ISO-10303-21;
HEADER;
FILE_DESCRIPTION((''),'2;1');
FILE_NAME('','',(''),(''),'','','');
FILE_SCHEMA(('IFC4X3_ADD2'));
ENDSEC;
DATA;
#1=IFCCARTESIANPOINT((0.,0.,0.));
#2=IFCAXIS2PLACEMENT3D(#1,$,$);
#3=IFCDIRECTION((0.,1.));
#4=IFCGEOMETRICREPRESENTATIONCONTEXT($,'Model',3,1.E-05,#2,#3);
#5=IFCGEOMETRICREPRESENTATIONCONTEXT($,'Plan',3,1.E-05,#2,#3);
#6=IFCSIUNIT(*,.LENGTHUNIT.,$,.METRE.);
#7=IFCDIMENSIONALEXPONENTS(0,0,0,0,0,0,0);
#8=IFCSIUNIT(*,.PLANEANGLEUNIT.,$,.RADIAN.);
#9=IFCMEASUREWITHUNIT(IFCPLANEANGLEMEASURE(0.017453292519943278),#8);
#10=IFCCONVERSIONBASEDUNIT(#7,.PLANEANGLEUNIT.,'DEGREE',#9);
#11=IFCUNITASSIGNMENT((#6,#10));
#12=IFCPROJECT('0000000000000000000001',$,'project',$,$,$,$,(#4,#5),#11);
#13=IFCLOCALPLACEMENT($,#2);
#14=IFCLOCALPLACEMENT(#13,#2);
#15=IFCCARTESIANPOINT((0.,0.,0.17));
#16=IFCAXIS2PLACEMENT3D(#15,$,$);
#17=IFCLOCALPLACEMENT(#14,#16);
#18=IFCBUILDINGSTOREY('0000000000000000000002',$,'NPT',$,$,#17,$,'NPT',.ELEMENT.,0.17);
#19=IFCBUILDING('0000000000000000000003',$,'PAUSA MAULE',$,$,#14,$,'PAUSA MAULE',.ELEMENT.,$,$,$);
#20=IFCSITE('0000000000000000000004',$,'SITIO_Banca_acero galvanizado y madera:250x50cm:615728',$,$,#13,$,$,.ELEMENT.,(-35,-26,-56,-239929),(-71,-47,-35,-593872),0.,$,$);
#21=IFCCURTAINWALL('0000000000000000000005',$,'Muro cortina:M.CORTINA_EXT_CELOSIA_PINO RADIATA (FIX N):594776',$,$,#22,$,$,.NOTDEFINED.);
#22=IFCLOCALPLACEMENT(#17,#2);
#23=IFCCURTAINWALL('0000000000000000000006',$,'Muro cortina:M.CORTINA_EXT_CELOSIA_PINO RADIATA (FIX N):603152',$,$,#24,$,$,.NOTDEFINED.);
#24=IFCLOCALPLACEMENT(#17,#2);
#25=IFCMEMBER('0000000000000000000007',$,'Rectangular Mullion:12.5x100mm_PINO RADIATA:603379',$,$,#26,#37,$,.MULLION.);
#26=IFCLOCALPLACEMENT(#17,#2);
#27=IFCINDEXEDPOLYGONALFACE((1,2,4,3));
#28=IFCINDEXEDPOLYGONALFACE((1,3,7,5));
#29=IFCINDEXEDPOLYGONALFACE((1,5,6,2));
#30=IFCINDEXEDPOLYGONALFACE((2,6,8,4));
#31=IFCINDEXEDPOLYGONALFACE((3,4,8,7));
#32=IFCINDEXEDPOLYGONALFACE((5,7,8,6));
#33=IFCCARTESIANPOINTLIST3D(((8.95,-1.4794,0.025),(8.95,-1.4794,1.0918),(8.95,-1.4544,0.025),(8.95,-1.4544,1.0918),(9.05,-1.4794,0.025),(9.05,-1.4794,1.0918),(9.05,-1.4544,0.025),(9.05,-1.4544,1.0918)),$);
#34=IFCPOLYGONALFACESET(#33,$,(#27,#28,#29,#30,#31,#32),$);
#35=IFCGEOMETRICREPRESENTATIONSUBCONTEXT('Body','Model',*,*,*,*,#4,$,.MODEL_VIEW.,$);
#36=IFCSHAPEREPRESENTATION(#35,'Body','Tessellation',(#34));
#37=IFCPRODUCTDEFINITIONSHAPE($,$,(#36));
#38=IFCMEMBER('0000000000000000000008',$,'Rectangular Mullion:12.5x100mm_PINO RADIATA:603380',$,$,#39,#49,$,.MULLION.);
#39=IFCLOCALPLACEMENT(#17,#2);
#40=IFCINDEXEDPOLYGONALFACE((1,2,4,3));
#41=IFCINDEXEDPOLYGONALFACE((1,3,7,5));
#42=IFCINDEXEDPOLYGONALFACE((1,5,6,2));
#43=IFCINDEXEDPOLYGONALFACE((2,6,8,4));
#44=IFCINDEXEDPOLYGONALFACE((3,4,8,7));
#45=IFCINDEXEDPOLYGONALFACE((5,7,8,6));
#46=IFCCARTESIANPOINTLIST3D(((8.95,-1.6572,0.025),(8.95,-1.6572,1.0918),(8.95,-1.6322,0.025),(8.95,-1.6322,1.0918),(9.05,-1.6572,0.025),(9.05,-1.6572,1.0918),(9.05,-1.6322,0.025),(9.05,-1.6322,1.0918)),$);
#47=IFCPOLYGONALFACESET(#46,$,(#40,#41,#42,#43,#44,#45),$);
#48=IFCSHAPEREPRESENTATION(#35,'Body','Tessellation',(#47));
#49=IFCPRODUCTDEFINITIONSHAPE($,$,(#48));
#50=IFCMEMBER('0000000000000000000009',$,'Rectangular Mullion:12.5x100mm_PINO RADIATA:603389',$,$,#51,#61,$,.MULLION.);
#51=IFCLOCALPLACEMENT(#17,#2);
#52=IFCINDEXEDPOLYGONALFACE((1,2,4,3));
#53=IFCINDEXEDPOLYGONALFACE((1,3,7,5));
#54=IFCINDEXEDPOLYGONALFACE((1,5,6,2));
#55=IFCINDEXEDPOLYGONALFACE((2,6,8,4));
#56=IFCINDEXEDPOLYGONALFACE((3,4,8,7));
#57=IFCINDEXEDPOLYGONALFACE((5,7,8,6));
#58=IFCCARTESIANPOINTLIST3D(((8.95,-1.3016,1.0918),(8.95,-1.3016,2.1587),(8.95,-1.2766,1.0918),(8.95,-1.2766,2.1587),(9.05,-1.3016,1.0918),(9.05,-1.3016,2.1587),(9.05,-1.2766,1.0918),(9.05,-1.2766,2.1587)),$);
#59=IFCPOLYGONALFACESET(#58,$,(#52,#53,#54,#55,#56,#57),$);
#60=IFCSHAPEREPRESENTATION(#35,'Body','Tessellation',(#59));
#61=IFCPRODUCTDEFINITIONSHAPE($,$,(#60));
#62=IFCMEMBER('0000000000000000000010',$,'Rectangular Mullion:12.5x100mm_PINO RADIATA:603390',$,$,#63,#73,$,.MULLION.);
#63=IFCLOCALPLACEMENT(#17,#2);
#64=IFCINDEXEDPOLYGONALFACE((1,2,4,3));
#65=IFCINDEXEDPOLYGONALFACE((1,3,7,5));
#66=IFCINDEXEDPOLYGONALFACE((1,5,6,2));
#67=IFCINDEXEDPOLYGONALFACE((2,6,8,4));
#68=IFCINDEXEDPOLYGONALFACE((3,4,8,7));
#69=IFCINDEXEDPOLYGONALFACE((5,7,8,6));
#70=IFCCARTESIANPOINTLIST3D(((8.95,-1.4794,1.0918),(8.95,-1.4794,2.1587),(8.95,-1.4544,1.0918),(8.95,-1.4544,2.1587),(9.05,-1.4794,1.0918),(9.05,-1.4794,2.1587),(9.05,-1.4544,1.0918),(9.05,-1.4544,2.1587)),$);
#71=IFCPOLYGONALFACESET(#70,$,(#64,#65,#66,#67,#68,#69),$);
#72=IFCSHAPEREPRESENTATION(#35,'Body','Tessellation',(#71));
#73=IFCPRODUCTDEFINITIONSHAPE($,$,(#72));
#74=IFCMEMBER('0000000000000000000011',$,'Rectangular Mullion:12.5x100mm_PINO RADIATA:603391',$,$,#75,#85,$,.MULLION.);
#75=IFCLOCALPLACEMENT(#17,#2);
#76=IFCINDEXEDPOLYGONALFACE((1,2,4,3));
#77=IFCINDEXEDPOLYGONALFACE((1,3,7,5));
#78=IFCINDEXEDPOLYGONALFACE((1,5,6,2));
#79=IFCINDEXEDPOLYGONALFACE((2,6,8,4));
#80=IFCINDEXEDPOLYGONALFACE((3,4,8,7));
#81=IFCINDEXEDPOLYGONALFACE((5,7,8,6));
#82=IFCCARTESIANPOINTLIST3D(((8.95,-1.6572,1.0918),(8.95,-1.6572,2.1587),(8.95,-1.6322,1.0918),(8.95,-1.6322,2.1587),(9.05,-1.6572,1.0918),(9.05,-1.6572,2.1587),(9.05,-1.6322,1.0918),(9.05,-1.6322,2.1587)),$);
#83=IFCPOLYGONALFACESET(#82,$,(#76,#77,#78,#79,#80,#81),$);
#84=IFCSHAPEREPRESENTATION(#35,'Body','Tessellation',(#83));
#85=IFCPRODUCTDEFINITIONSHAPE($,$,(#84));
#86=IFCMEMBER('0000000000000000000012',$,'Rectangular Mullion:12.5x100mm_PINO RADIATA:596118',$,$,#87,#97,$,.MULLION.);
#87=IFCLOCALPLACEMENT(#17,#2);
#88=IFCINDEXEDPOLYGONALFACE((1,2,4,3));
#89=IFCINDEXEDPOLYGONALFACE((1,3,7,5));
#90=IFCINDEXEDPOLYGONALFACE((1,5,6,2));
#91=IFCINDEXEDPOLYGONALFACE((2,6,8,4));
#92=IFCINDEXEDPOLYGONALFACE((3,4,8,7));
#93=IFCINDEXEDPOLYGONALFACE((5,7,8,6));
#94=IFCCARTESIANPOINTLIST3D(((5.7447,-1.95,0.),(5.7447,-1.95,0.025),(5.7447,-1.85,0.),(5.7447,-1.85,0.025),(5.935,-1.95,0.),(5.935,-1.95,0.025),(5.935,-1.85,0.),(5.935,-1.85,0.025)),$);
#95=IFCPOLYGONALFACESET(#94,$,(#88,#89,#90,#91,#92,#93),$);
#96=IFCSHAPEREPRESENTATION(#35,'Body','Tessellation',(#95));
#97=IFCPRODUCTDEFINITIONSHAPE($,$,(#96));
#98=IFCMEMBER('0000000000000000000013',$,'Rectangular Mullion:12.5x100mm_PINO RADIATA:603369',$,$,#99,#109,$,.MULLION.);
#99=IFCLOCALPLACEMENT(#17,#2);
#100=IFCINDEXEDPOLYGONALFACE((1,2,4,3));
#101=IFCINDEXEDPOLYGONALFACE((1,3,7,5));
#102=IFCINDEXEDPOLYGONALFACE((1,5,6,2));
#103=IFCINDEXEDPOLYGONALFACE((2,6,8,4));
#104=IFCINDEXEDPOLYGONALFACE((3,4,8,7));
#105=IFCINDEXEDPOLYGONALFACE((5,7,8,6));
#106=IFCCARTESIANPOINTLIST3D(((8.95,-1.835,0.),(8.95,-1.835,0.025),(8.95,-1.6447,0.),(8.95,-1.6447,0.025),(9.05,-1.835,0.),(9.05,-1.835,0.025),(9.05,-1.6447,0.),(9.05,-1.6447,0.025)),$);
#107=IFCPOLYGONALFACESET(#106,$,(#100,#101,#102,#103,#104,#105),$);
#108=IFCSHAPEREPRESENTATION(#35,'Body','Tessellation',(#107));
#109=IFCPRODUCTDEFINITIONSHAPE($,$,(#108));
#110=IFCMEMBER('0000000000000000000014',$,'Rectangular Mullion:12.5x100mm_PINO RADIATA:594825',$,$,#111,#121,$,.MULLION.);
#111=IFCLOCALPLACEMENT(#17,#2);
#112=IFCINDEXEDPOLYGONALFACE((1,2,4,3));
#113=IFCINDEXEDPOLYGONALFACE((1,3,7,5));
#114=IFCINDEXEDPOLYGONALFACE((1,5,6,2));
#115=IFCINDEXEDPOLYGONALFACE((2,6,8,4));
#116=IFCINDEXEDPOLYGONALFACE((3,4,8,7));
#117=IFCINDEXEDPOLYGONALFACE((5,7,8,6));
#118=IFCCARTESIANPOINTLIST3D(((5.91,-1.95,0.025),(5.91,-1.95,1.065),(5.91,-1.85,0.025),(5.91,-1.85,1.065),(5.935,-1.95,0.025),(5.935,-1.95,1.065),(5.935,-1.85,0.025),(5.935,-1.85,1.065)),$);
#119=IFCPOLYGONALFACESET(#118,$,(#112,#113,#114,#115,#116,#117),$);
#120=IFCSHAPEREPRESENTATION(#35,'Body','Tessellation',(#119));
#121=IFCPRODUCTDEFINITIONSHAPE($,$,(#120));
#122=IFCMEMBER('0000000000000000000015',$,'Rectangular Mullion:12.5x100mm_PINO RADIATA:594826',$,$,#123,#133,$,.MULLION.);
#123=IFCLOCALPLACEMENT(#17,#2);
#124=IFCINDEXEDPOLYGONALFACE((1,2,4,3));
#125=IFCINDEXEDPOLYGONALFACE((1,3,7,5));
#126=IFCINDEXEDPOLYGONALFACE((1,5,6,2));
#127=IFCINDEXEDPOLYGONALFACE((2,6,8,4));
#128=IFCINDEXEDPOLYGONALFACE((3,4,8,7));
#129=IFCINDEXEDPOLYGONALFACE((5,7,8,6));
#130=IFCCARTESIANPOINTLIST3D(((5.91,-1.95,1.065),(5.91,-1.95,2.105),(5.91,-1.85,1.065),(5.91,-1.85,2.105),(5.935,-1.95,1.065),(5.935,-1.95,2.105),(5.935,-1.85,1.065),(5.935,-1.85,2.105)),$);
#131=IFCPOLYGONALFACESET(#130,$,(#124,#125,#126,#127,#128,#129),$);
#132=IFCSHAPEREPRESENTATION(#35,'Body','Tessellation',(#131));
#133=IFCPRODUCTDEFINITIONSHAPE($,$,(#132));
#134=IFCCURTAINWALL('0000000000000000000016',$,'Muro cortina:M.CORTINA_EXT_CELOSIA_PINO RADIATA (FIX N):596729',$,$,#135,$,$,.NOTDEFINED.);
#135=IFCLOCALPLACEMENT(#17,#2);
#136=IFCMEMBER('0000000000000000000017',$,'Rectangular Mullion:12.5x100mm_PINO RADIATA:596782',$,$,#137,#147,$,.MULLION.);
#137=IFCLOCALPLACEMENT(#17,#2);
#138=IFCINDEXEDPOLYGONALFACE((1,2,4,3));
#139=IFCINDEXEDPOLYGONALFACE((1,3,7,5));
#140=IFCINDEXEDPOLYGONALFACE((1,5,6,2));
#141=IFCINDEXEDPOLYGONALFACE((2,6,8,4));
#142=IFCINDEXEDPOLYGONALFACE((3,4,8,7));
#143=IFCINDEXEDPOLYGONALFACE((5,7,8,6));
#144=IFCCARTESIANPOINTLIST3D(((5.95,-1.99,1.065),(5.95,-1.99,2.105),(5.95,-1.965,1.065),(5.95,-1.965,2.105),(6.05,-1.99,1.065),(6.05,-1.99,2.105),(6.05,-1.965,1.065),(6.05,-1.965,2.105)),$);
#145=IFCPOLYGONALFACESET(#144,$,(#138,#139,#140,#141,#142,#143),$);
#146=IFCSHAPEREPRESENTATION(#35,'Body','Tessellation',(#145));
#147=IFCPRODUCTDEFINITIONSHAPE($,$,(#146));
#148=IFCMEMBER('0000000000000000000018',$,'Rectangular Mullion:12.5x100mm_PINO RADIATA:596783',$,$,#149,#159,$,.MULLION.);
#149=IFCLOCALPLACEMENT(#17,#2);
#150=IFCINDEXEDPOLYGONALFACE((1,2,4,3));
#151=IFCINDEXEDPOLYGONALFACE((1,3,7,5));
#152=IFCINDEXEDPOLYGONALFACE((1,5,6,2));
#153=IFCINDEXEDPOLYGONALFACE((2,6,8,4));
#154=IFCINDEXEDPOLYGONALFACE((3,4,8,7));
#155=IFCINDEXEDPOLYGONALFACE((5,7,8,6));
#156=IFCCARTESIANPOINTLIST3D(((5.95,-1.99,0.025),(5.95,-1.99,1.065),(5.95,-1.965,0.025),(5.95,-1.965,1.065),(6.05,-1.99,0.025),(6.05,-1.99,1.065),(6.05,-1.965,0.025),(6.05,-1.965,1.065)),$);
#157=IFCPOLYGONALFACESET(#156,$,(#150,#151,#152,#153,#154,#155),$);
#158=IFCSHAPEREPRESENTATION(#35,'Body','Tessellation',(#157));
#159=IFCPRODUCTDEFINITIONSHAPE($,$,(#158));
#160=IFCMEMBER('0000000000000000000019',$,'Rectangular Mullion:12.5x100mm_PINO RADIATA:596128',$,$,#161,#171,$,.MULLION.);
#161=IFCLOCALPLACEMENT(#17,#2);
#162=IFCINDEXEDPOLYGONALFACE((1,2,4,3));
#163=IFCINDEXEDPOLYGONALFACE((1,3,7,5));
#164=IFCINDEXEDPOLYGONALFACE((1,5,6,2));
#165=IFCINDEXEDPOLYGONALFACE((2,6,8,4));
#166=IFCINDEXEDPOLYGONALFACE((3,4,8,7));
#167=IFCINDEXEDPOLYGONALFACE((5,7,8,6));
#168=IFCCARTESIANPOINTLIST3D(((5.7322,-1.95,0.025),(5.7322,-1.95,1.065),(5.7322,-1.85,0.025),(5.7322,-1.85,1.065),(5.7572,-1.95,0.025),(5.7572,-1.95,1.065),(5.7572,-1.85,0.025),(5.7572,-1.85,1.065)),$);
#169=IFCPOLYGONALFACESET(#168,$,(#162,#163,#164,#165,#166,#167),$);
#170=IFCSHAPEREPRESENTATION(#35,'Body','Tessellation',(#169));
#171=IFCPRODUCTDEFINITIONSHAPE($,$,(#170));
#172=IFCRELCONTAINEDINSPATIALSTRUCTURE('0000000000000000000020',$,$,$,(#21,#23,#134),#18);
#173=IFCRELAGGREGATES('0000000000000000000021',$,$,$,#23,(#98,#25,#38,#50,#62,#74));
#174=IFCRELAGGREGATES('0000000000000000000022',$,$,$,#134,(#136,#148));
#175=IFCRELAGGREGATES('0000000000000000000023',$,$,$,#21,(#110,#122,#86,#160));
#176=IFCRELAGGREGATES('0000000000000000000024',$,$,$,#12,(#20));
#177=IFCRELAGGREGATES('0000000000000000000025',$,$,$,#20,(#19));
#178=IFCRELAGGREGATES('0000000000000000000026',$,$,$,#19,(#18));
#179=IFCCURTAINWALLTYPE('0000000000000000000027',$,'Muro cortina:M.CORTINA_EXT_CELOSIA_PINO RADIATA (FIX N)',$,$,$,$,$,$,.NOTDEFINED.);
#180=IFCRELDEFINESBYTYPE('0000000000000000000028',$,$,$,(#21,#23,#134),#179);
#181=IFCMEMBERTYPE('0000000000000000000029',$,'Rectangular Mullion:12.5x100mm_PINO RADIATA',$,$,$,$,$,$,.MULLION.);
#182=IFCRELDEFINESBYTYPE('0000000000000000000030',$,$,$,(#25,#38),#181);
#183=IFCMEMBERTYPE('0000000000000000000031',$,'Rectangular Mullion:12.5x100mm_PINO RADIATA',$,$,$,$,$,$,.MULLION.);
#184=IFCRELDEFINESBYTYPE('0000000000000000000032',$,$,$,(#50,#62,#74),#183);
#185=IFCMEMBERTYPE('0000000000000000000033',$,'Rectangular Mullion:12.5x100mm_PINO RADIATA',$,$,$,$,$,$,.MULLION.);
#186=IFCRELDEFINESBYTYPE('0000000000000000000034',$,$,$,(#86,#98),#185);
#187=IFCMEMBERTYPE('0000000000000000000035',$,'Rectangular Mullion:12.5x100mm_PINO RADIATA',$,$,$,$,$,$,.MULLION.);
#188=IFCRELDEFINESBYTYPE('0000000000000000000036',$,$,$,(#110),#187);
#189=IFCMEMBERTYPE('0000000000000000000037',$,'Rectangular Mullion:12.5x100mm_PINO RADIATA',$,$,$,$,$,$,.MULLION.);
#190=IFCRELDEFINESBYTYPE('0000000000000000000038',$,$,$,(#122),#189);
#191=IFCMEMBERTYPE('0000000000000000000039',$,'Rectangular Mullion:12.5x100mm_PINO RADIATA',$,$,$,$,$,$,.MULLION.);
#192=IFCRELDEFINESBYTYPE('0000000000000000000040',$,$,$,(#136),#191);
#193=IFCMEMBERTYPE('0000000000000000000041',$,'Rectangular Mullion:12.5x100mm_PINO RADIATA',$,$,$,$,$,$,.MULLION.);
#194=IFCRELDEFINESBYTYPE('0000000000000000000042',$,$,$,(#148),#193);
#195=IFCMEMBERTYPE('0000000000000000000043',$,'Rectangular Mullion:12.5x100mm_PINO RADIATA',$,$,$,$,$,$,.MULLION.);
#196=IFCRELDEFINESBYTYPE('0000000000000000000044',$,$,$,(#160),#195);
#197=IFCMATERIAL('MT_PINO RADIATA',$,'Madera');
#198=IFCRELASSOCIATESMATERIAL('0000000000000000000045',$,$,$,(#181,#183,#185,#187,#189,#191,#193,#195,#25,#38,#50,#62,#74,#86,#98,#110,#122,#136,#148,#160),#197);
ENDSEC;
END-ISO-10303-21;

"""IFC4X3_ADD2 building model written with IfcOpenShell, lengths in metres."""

from ifc_helpers import new_model, entity, si_unit, converted_unit, direction, frame, frame_2d, origin, origin_2d_with_axis, place, context, subcontext, project, spatial, rectangle, extrude, source, transform, mapped, material, material_profile, profile_set, profile_usage, type_object, type_shapes, element, aggregate, save


model = new_model("IFC4X3_ADD2")

# Units and contexts
model_context = context("Model", 3, precision=1e-05, world=origin(), true_north=direction((0.0, 1.0)))
plan_context = context("Plan", 3, precision=1e-05, world=origin(), true_north=direction((0.0, 1.0)))
body_context = subcontext(model_context, "Body", "Model", "MODEL_VIEW")
ifc_project = project(units=[si_unit("LENGTHUNIT", "METRE"), converted_unit("PLANEANGLEUNIT", "DEGREE", entity("IfcPlaneAngleMeasure", 0.017453292519943278), si_unit("PLANEANGLEUNIT", "RADIAN"), dimensions=[0, 0, 0, 0, 0, 0, 0])], contexts=[model_context, plan_context])

# Site, building, storey
site_placement = place(None, origin())
site = spatial("IfcSite", under=ifc_project, at=site_placement, Name="SITIO_Banca_acero galvanizado y madera:250x50cm:615728", CompositionType="ELEMENT", RefLatitude=(-35, -26, -56, -239929), RefLongitude=(-71, -47, -35, -593872), RefElevation=0.0)
building_placement = place(site_placement, origin())
building = spatial("IfcBuilding", under=site, at=building_placement, Name="PAUSA MAULE", LongName="PAUSA MAULE", CompositionType="ELEMENT")
storey_placement = place(building_placement, frame((0.0, 0.0, 0.17)))
storey = spatial("IfcBuildingStorey", under=building, at=storey_placement, Name="NPT", LongName="NPT", CompositionType="ELEMENT", Elevation=0.17)

# Curtain walls
curtain_wall_type = type_object("IfcCurtainWallType", Name="Muro cortina:M.CORTINA_EXT_CELOSIA_PINO RADIATA (FIX N)", PredefinedType="NOTDEFINED")
curtain_wall_1_placement = place(storey_placement, frame((0.0, 0.0, -0.17)))
curtain_wall_1 = element("IfcCurtainWall", 1, at=curtain_wall_1_placement, inside=storey, type_object=curtain_wall_type, Name="Muro cortina:M.CORTINA_EXT_CELOSIA_PINO RADIATA (FIX N):594776", PredefinedType="NOTDEFINED")
ifc_material = material(Name="MT_PINO RADIATA", Category="Madera")
ifc_material_profile = material_profile(ifc_material, rectangle(XDim=0.025, YDim=0.1, at=frame_2d((0.0, 0.0), x_axis=(1.0, 0.0))), Name="12.5x100mm_PINO RADIATA")
ifc_profile_set = profile_set([ifc_material_profile], Name="12.5x100mm_PINO RADIATA")
ifc_profile_usage = profile_usage(ifc_profile_set)
curtain_wall_2_placement = place(storey_placement, frame((0.0, 0.0, -0.17)))
curtain_wall_2 = element("IfcCurtainWall", 2, at=curtain_wall_2_placement, inside=storey, type_object=curtain_wall_type, Name="Muro cortina:M.CORTINA_EXT_CELOSIA_PINO RADIATA (FIX N):603152", PredefinedType="NOTDEFINED")

# Members
member_type_1 = type_object("IfcMemberType", Name="Rectangular Mullion:12.5x100mm_PINO RADIATA", PredefinedType="MULLION", material=ifc_profile_set)
shared_shape_1 = source(origin(), body_context, "Body", "SweptSolid", [
    extrude(rectangle(XDim=0.025, YDim=0.1, at=origin_2d_with_axis()), frame((0.0, 0.0, -1.0668), z_axis=(0.0, 0.0, 1.0), x_axis=(-1.0, 0.0, 0.0)), (0.0, 0.0, 1.0), 1.0668),
])
type_shapes(member_type_1, [shared_shape_1])
member_1_placement = place(curtain_wall_2_placement, frame((9.0, -1.4669, 0.195), z_axis=(0.0, 0.0, -1.0), x_axis=(0.0, -1.0, 0.0)))
member_1 = element("IfcMember", 3, at=member_1_placement, type_object=member_type_1, material=ifc_profile_usage, Name="Rectangular Mullion:12.5x100mm_PINO RADIATA:603379", PredefinedType="MULLION", context=body_context, shape_type="MappedRepresentation", body=[
    mapped(shared_shape_1, transform((0.0, 0.0, 0.0), scale=1.0)),
])
member_2_placement = place(curtain_wall_2_placement, frame((9.0, -1.6447, 0.195), z_axis=(0.0, 0.0, -1.0), x_axis=(0.0, -1.0, 0.0)))
member_2 = element("IfcMember", 4, at=member_2_placement, type_object=member_type_1, material=ifc_profile_usage, Name="Rectangular Mullion:12.5x100mm_PINO RADIATA:603380", PredefinedType="MULLION", context=body_context, shape_type="MappedRepresentation", body=[
    mapped(shared_shape_1, transform((0.0, 0.0, 0.0), scale=1.0)),
])
member_type_2 = type_object("IfcMemberType", Name="Rectangular Mullion:12.5x100mm_PINO RADIATA", PredefinedType="MULLION", material=ifc_profile_set)
shared_shape_2 = source(origin(), body_context, "Body", "SweptSolid", [
    extrude(rectangle(XDim=0.025, YDim=0.1, at=origin_2d_with_axis()), frame((0.0, 0.0, -1.0668), z_axis=(0.0, 0.0, 1.0), x_axis=(-1.0, 0.0, 0.0)), (0.0, 0.0, 1.0), 1.0668),
])
type_shapes(member_type_2, [shared_shape_2])
member_3_placement = place(curtain_wall_2_placement, frame((9.0, -1.2891, 1.2618), z_axis=(0.0, 0.0, -1.0), x_axis=(0.0, -1.0, 0.0)))
member_3 = element("IfcMember", 5, at=member_3_placement, type_object=member_type_2, material=ifc_profile_usage, Name="Rectangular Mullion:12.5x100mm_PINO RADIATA:603389", PredefinedType="MULLION", context=body_context, shape_type="MappedRepresentation", body=[
    mapped(shared_shape_2, transform((0.0, 0.0, 0.0), scale=1.0)),
])
member_4_placement = place(curtain_wall_2_placement, frame((9.0, -1.4669, 1.2618), z_axis=(0.0, 0.0, -1.0), x_axis=(0.0, -1.0, 0.0)))
member_4 = element("IfcMember", 6, at=member_4_placement, type_object=member_type_2, material=ifc_profile_usage, Name="Rectangular Mullion:12.5x100mm_PINO RADIATA:603390", PredefinedType="MULLION", context=body_context, shape_type="MappedRepresentation", body=[
    mapped(shared_shape_2, transform((0.0, 0.0, 0.0), scale=1.0)),
])
member_5_placement = place(curtain_wall_2_placement, frame((9.0, -1.6447, 1.2618), z_axis=(0.0, 0.0, -1.0), x_axis=(0.0, -1.0, 0.0)))
member_5 = element("IfcMember", 7, at=member_5_placement, type_object=member_type_2, material=ifc_profile_usage, Name="Rectangular Mullion:12.5x100mm_PINO RADIATA:603391", PredefinedType="MULLION", context=body_context, shape_type="MappedRepresentation", body=[
    mapped(shared_shape_2, transform((0.0, 0.0, 0.0), scale=1.0)),
])
member_type_3 = type_object("IfcMemberType", Name="Rectangular Mullion:12.5x100mm_PINO RADIATA", PredefinedType="MULLION", material=ifc_profile_set)
shared_shape_3 = source(origin(), body_context, "Body", "SweptSolid", [
    extrude(rectangle(XDim=0.025, YDim=0.1, at=frame_2d((0.0, 0.0), x_axis=(1.0, 0.0))), frame((-0.0125, 0.0, -0.1903), z_axis=(0.0, 0.0, 1.0), x_axis=(-1.0, 0.0, 0.0)), (0.0, 0.0, 1.0), 0.1903),
])
type_shapes(member_type_3, [shared_shape_3])
member_6_placement = place(curtain_wall_1_placement, frame((5.7447, -1.9, 0.17), z_axis=(-1.0, 0.0, 0.0), x_axis=(0.0, 0.0, -1.0)))
member_6 = element("IfcMember", 8, at=member_6_placement, type_object=member_type_3, material=ifc_profile_usage, Name="Rectangular Mullion:12.5x100mm_PINO RADIATA:596118", PredefinedType="MULLION", context=body_context, shape_type="MappedRepresentation", body=[
    mapped(shared_shape_3, transform((0.0, 0.0, 0.0), scale=1.0)),
])
member_7_placement = place(curtain_wall_2_placement, frame((9.0, -1.6447, 0.17), z_axis=(0.0, 1.0, 0.0), x_axis=(0.0, 0.0, -1.0)))
member_7 = element("IfcMember", 9, at=member_7_placement, type_object=member_type_3, material=ifc_profile_usage, Name="Rectangular Mullion:12.5x100mm_PINO RADIATA:603369", PredefinedType="MULLION", context=body_context, shape_type="MappedRepresentation", body=[
    mapped(shared_shape_3, transform((0.0, 0.0, 0.0), scale=1.0)),
])
aggregate(curtain_wall_2, [member_7, member_1, member_2, member_3, member_4, member_5])
member_type_4 = type_object("IfcMemberType", Name="Rectangular Mullion:12.5x100mm_PINO RADIATA", PredefinedType="MULLION", material=ifc_profile_set)
shared_shape_4 = source(origin(), body_context, "Body", "SweptSolid", [
    extrude(rectangle(XDim=0.025, YDim=0.1, at=origin_2d_with_axis()), frame((-0.0125, 0.0, -1.04), z_axis=(0.0, 0.0, 1.0), x_axis=(-1.0, 0.0, 0.0)), (0.0, 0.0, 1.0), 1.04),
])
type_shapes(member_type_4, [shared_shape_4])
member_8_placement = place(curtain_wall_1_placement, frame((5.935, -1.9, 0.195), z_axis=(0.0, 0.0, -1.0), x_axis=(1.0, 0.0, 0.0)))
member_8 = element("IfcMember", 10, at=member_8_placement, type_object=member_type_4, material=ifc_profile_usage, Name="Rectangular Mullion:12.5x100mm_PINO RADIATA:594825", PredefinedType="MULLION", context=body_context, shape_type="MappedRepresentation", body=[
    mapped(shared_shape_4, transform((0.0, 0.0, 0.0), scale=1.0)),
])
member_type_5 = type_object("IfcMemberType", Name="Rectangular Mullion:12.5x100mm_PINO RADIATA", PredefinedType="MULLION", material=ifc_profile_set)
shared_shape_5 = source(origin(), body_context, "Body", "SweptSolid", [
    extrude(rectangle(XDim=0.025, YDim=0.1, at=origin_2d_with_axis()), frame((-0.0125, 0.0, -1.04), z_axis=(0.0, 0.0, 1.0), x_axis=(-1.0, 0.0, 0.0)), (0.0, 0.0, 1.0), 1.04),
])
type_shapes(member_type_5, [shared_shape_5])
member_9_placement = place(curtain_wall_1_placement, frame((5.935, -1.9, 1.235), z_axis=(0.0, 0.0, -1.0), x_axis=(1.0, 0.0, 0.0)))
member_9 = element("IfcMember", 11, at=member_9_placement, type_object=member_type_5, material=ifc_profile_usage, Name="Rectangular Mullion:12.5x100mm_PINO RADIATA:594826", PredefinedType="MULLION", context=body_context, shape_type="MappedRepresentation", body=[
    mapped(shared_shape_5, transform((0.0, 0.0, 0.0), scale=1.0)),
])

# Curtain wall, members
curtain_wall_3_placement = place(storey_placement, frame((0.0, 0.0, -0.17)))
curtain_wall_3 = element("IfcCurtainWall", 12, at=curtain_wall_3_placement, inside=storey, type_object=curtain_wall_type, Name="Muro cortina:M.CORTINA_EXT_CELOSIA_PINO RADIATA (FIX N):596729", PredefinedType="NOTDEFINED")
member_type_6 = type_object("IfcMemberType", Name="Rectangular Mullion:12.5x100mm_PINO RADIATA", PredefinedType="MULLION", material=ifc_profile_set)
shared_shape_6 = source(origin(), body_context, "Body", "SweptSolid", [
    extrude(rectangle(XDim=0.025, YDim=0.1, at=origin_2d_with_axis()), frame((-0.0125, 0.0, -1.04), z_axis=(0.0, 0.0, 1.0), x_axis=(-1.0, 0.0, 0.0)), (0.0, 0.0, 1.0), 1.04),
])
type_shapes(member_type_6, [shared_shape_6])
member_10_placement = place(curtain_wall_3_placement, frame((6.0, -1.965, 2.275), z_axis=(0.0, 0.0, 1.0), x_axis=(0.0, 1.0, 0.0)))
member_10 = element("IfcMember", 13, at=member_10_placement, type_object=member_type_6, material=ifc_profile_usage, Name="Rectangular Mullion:12.5x100mm_PINO RADIATA:596782", PredefinedType="MULLION", context=body_context, shape_type="MappedRepresentation", body=[
    mapped(shared_shape_6, transform((0.0, 0.0, 0.0), scale=1.0)),
])
member_type_7 = type_object("IfcMemberType", Name="Rectangular Mullion:12.5x100mm_PINO RADIATA", PredefinedType="MULLION", material=ifc_profile_set)
shared_shape_7 = source(origin(), body_context, "Body", "SweptSolid", [
    extrude(rectangle(XDim=0.025, YDim=0.1, at=origin_2d_with_axis()), frame((-0.0125, 0.0, -1.04), z_axis=(0.0, 0.0, 1.0), x_axis=(-1.0, 0.0, 0.0)), (0.0, 0.0, 1.0), 1.04),
])
type_shapes(member_type_7, [shared_shape_7])
member_11_placement = place(curtain_wall_3_placement, frame((6.0, -1.965, 1.235), z_axis=(0.0, 0.0, 1.0), x_axis=(0.0, 1.0, 0.0)))
member_11 = element("IfcMember", 14, at=member_11_placement, type_object=member_type_7, material=ifc_profile_usage, Name="Rectangular Mullion:12.5x100mm_PINO RADIATA:596783", PredefinedType="MULLION", context=body_context, shape_type="MappedRepresentation", body=[
    mapped(shared_shape_7, transform((0.0, 0.0, 0.0), scale=1.0)),
])
aggregate(curtain_wall_3, [member_10, member_11])

# Member
member_type_8 = type_object("IfcMemberType", Name="Rectangular Mullion:12.5x100mm_PINO RADIATA", PredefinedType="MULLION", material=ifc_profile_set)
shared_shape_8 = source(origin(), body_context, "Body", "SweptSolid", [
    extrude(rectangle(XDim=0.025, YDim=0.1, at=frame_2d((0.0, 0.0), x_axis=(1.0, 0.0))), frame((0.0, 0.0, -1.04), z_axis=(0.0, 0.0, 1.0), x_axis=(-1.0, 0.0, 0.0)), (0.0, 0.0, 1.0), 1.04),
])
type_shapes(member_type_8, [shared_shape_8])
member_12_placement = place(curtain_wall_1_placement, frame((5.7447, -1.9, 0.195), z_axis=(0.0, 0.0, -1.0), x_axis=(1.0, 0.0, 0.0)))
member_12 = element("IfcMember", 15, at=member_12_placement, type_object=member_type_8, material=ifc_profile_usage, Name="Rectangular Mullion:12.5x100mm_PINO RADIATA:596128", PredefinedType="MULLION", context=body_context, shape_type="MappedRepresentation", body=[
    mapped(shared_shape_8, transform((0.0, 0.0, 0.0), scale=1.0)),
])
aggregate(curtain_wall_1, [member_8, member_9, member_6, member_12])

save(model, "model.ifc")
